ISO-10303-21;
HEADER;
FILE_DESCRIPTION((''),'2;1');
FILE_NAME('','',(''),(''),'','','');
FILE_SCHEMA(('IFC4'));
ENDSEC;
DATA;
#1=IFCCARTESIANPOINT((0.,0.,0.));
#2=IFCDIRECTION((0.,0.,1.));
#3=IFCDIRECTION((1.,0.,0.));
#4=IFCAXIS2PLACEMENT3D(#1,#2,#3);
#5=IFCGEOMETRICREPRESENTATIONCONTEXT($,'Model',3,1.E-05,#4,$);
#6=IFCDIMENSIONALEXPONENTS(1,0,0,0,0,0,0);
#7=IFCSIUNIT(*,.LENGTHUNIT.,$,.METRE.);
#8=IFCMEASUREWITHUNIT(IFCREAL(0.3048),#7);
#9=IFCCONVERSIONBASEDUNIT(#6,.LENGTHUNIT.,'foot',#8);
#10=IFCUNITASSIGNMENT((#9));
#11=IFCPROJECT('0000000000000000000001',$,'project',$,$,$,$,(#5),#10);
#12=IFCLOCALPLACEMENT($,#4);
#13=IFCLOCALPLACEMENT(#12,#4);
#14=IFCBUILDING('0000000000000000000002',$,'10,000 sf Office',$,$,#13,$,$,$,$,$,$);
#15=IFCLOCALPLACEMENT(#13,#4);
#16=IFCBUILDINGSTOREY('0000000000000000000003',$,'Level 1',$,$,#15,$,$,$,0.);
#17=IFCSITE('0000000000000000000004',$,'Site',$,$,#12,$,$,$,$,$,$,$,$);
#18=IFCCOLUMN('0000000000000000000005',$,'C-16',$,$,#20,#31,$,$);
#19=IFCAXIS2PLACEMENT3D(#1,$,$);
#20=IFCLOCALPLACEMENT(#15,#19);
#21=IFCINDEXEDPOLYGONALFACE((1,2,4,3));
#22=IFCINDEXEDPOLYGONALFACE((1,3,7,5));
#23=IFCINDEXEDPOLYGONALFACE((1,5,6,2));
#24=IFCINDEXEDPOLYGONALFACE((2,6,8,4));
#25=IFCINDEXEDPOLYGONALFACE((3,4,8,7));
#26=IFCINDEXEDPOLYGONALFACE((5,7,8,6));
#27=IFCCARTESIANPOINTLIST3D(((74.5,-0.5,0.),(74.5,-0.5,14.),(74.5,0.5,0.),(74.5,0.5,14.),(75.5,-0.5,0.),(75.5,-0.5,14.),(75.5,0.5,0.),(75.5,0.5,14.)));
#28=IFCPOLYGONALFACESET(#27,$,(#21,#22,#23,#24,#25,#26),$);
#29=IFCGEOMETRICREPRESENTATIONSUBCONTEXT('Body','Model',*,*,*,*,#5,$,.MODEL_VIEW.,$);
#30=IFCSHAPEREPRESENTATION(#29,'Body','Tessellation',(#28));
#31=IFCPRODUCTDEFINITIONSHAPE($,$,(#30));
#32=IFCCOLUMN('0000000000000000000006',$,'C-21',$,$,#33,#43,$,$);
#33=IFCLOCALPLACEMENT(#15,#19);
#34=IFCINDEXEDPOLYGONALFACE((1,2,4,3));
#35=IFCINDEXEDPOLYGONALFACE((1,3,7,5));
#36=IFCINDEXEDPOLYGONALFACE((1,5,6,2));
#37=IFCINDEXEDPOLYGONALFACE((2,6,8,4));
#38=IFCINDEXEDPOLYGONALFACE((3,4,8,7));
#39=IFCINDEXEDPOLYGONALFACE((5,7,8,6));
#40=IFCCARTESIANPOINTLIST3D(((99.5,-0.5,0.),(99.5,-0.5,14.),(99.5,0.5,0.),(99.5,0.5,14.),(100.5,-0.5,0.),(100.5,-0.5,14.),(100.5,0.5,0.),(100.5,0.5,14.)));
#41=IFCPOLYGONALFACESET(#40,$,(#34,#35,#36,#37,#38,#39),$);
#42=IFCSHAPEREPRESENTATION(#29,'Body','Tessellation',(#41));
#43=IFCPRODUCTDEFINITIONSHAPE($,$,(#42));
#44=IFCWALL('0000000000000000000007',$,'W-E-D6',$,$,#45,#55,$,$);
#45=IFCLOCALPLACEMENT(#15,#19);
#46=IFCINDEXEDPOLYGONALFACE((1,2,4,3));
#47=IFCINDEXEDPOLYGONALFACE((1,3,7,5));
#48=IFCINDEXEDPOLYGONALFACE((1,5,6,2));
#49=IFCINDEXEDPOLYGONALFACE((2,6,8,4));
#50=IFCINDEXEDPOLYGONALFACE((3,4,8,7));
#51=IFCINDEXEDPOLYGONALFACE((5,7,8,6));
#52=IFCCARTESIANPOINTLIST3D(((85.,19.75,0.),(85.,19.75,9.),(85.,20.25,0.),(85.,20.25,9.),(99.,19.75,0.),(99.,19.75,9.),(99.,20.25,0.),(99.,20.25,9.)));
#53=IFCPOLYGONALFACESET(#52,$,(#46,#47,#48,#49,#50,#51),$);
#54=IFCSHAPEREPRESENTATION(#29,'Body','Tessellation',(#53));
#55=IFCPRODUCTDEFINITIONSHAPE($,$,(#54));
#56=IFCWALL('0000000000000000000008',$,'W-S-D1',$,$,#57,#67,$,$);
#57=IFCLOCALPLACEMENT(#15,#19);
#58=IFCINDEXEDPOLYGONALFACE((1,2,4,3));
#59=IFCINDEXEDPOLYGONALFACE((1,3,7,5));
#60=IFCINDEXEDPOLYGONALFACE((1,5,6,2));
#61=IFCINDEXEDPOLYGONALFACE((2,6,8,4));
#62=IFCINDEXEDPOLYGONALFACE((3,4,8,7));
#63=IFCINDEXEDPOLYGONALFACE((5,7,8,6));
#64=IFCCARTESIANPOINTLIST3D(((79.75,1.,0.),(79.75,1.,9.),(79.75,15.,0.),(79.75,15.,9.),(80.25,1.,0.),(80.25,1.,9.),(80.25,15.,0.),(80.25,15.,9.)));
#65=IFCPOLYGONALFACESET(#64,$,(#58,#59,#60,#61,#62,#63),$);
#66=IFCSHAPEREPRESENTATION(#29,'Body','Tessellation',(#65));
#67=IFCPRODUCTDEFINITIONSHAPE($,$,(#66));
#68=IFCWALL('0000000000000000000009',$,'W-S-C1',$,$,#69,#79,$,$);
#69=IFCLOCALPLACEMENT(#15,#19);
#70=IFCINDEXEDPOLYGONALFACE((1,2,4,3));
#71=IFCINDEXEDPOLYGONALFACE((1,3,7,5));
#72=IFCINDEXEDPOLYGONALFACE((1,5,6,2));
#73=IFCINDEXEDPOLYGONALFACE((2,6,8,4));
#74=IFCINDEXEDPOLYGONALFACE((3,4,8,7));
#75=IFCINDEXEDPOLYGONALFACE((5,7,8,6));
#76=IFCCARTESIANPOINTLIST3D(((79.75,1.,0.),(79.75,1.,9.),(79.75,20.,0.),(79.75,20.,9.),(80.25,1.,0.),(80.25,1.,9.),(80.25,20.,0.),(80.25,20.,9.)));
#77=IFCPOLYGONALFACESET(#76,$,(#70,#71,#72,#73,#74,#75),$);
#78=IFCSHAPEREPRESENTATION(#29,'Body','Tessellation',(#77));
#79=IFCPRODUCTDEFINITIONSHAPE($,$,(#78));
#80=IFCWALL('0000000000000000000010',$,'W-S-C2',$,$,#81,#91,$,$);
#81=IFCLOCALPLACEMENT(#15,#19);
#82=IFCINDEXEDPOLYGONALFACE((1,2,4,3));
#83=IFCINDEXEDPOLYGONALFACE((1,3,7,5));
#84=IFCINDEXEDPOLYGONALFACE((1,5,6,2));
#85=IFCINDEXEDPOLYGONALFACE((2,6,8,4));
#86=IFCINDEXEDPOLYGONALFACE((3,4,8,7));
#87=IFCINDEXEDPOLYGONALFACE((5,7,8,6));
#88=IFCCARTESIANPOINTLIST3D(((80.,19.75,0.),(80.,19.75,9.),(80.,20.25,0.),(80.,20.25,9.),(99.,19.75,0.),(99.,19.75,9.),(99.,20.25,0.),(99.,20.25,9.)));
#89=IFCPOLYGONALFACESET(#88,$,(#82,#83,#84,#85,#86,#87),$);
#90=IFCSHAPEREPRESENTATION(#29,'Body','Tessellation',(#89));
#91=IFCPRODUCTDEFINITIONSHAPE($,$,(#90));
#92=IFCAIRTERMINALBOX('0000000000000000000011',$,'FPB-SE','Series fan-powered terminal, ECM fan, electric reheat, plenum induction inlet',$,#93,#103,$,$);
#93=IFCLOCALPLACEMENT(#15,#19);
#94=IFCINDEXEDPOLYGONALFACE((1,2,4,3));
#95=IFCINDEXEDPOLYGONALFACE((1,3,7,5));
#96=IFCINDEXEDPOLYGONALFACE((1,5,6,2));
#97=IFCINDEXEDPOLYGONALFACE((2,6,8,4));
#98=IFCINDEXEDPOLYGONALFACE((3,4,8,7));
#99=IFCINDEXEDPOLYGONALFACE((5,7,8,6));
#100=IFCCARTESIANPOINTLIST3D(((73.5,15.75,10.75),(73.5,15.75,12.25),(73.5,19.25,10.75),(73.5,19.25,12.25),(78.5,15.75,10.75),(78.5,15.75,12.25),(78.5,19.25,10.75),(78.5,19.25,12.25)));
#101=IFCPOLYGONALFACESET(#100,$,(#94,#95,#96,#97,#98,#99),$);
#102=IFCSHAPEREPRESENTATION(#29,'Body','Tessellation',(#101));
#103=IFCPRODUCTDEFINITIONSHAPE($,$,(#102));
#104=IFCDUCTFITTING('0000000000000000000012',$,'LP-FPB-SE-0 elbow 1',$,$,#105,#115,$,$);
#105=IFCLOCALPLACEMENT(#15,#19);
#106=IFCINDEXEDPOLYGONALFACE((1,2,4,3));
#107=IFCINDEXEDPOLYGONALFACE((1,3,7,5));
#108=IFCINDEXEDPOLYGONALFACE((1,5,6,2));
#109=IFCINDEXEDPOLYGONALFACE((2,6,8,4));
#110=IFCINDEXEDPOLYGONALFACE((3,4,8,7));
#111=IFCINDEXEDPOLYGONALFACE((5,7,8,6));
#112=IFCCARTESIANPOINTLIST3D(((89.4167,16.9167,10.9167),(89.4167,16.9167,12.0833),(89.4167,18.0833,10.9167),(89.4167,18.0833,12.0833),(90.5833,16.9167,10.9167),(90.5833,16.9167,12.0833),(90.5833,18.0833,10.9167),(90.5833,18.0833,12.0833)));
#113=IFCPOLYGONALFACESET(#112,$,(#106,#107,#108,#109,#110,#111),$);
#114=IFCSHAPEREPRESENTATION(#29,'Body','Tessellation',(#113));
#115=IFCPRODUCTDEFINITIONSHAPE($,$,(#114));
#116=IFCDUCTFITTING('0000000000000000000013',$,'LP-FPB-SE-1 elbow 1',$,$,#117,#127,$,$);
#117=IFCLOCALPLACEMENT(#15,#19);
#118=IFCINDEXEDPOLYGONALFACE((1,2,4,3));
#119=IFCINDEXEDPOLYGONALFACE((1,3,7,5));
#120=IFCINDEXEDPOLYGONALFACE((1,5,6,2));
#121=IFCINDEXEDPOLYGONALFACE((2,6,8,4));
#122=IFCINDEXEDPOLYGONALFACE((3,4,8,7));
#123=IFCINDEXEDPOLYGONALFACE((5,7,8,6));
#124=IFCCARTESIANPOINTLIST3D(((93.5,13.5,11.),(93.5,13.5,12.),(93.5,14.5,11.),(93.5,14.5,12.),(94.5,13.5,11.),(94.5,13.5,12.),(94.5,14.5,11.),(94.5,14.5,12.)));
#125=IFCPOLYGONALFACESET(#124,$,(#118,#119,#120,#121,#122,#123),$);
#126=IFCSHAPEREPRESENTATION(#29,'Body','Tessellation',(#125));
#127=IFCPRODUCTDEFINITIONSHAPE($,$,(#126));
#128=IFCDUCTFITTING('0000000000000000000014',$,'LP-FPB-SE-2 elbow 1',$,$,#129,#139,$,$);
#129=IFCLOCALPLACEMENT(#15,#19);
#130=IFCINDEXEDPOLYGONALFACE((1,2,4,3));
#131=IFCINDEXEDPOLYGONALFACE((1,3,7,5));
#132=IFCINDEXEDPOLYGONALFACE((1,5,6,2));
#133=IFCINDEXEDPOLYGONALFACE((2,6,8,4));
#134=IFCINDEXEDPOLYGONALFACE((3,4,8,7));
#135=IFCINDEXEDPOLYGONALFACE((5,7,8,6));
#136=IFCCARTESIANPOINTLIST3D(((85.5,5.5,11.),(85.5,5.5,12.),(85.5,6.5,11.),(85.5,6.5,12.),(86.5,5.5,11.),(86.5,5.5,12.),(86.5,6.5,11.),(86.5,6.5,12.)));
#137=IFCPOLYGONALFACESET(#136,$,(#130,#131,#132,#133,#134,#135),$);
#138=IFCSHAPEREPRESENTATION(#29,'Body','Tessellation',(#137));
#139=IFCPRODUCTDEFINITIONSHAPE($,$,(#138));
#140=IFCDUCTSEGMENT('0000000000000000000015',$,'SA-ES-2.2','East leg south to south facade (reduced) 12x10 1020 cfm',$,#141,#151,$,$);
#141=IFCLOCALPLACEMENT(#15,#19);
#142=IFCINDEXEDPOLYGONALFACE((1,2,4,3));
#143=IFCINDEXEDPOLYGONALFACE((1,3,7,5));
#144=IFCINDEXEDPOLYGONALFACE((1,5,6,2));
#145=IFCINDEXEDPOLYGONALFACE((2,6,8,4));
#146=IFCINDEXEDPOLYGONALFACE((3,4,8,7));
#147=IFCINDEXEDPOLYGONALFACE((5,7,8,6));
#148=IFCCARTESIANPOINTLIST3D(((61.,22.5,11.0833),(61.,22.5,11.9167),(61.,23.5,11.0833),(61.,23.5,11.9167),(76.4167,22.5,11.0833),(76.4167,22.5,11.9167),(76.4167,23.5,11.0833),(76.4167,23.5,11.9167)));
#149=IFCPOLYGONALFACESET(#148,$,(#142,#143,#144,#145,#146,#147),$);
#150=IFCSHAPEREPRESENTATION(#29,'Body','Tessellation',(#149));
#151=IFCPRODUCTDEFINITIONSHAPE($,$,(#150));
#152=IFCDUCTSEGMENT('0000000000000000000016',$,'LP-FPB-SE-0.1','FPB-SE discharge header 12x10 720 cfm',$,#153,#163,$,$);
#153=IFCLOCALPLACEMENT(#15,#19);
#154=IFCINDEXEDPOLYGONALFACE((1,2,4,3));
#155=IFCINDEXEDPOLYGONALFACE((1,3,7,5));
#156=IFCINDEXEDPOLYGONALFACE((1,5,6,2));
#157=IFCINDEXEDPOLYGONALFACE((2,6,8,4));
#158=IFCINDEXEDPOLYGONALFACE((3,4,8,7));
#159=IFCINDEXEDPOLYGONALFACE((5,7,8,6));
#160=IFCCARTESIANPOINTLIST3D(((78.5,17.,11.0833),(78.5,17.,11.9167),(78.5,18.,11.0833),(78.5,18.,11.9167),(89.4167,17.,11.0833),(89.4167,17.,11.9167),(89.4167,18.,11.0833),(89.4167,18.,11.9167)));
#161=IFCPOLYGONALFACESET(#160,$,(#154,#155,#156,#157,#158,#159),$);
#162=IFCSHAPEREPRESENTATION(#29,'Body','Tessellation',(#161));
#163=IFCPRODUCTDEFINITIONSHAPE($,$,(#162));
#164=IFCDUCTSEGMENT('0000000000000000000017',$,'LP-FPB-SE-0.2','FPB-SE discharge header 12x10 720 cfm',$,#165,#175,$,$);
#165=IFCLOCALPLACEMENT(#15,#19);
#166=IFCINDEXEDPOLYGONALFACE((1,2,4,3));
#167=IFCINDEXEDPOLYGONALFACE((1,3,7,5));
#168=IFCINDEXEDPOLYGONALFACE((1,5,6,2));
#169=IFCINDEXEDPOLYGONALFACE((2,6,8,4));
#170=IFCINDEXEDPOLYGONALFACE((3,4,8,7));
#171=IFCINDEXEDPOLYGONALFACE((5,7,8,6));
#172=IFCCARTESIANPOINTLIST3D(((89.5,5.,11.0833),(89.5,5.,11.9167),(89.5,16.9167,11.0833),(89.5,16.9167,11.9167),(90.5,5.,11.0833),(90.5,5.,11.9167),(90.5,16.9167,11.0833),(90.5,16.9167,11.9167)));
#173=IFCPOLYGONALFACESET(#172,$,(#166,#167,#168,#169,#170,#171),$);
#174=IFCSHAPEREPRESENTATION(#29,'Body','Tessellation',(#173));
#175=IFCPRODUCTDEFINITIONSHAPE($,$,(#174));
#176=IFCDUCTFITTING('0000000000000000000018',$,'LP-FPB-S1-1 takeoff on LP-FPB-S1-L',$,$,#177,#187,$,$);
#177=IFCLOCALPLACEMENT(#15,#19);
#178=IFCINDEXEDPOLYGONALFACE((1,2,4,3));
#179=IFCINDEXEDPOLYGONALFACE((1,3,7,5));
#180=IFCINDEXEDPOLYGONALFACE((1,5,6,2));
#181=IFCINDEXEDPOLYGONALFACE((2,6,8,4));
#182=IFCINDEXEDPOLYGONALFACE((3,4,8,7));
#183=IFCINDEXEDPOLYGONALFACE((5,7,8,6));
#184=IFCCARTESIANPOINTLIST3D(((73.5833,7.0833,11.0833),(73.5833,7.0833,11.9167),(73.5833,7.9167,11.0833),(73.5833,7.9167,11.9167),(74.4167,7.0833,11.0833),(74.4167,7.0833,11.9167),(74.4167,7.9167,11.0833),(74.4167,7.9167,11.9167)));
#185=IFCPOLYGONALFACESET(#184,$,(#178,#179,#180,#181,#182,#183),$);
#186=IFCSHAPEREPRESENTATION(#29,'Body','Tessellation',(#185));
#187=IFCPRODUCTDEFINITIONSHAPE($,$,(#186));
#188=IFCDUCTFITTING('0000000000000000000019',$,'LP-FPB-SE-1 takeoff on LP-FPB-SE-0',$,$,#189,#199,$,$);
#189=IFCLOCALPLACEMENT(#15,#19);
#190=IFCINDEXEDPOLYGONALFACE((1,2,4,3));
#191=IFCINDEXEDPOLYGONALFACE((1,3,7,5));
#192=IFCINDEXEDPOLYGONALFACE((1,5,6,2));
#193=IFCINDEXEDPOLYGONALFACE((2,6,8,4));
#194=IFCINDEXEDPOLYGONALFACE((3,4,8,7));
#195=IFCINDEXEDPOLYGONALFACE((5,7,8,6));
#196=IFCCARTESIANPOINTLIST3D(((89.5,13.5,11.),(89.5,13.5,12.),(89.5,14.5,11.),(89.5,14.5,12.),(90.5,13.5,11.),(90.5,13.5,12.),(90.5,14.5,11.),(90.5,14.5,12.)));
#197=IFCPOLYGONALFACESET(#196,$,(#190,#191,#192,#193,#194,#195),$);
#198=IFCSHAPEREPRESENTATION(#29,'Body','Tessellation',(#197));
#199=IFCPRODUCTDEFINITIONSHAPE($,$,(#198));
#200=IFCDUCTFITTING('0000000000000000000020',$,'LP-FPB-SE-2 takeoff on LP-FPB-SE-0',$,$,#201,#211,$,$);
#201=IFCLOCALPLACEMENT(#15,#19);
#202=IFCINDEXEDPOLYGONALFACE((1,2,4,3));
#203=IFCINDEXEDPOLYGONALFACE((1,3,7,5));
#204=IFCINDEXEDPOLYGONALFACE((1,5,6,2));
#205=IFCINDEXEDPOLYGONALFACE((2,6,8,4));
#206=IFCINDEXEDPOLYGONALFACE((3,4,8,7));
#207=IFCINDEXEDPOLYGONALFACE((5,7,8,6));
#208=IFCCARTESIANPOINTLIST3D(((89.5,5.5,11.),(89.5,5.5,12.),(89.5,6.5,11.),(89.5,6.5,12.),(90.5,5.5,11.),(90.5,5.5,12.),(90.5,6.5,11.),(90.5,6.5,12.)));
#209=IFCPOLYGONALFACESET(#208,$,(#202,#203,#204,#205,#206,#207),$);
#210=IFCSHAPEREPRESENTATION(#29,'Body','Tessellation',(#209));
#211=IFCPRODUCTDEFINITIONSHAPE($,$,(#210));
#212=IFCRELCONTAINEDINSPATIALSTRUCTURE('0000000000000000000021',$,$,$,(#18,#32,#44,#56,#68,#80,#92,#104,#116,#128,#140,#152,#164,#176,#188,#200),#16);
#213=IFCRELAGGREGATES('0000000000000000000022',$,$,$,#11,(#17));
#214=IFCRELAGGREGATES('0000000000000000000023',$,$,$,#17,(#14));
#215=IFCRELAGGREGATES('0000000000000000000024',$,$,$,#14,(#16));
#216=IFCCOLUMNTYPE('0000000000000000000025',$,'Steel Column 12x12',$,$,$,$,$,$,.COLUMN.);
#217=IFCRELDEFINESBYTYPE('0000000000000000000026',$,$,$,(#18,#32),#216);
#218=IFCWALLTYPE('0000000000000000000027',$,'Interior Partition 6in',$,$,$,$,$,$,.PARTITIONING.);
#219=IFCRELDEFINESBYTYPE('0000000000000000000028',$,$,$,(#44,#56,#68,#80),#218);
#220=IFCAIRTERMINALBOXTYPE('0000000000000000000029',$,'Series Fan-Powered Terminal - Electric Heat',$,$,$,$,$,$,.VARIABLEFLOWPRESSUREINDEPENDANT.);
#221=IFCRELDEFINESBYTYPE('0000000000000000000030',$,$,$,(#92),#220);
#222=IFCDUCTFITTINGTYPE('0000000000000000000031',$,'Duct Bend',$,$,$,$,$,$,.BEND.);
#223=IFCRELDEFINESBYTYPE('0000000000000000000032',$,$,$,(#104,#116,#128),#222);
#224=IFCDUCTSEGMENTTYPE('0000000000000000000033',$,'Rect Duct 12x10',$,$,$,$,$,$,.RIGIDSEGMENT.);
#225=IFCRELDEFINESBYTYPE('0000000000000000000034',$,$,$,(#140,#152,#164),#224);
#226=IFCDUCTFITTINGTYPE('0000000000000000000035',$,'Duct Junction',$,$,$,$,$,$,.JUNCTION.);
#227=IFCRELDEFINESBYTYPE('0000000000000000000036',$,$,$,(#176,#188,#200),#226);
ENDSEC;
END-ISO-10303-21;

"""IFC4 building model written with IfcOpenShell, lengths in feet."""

from ifc_helpers import new_model, entity, si_unit, converted_unit, frame, origin_with_axes, place, context, subcontext, project, spatial, rectangle, extrude, type_object, element, save


model = new_model("IFC4")

# Units and contexts
model_context = context("Model", 3, precision=1e-05, world=origin_with_axes())
body_context = subcontext(model_context, "Body", "Model", "MODEL_VIEW")
ifc_project = project(units=[converted_unit("LENGTHUNIT", "foot", entity("IfcReal", 0.3048), si_unit("LENGTHUNIT", "METRE"), dimensions=[1, 0, 0, 0, 0, 0, 0])], contexts=[model_context])

# Site, building, storey
site_placement = place(None, origin_with_axes())
site = spatial("IfcSite", under=ifc_project, at=site_placement, Name="Site")
building_placement = place(site_placement, origin_with_axes())
building = spatial("IfcBuilding", under=site, at=building_placement, Name="10,000 sf Office")
storey_placement = place(building_placement, origin_with_axes())
storey = spatial("IfcBuildingStorey", under=building, at=storey_placement, Name="Level 1", Elevation=0.0)

# Columns
column_type = type_object("IfcColumnType", Name="Steel Column 12x12", PredefinedType="COLUMN")
for number, where, z_axis, x_axis, name in (
    (1, (75.0, 0.0, 0.0), (0.0, 0.0, 1.0), (1.0, 0.0, 0.0), "C-16"),
    (2, (100.0, 0.0, 0.0), (0.0, 0.0, 1.0), (1.0, 0.0, 0.0), "C-21"),
):
    element("IfcColumn", number, at=place(storey_placement, frame(where, z_axis=z_axis, x_axis=x_axis)), inside=storey, type_object=column_type, Name=name, context=body_context, shape_type="SweptSolid", body=[
        extrude(rectangle(XDim=1.0, YDim=1.0), None, (0.0, 0.0, 1.0), 14.0),
    ])

# Walls
wall_type = type_object("IfcWallType", Name="Interior Partition 6in", PredefinedType="PARTITIONING")
for number, where, z_axis, x_axis, name in (
    (3, (92.0, 20.0, 0.0), (0.0, 0.0, 1.0), (-1.0, 0.0, 0.0), "W-E-D6"),
    (4, (80.0, 8.0, 0.0), (0.0, 0.0, 1.0), (0.0, 1.0, 0.0), "W-S-D1"),
):
    element("IfcWall", number, at=place(storey_placement, frame(where, z_axis=z_axis, x_axis=x_axis)), inside=storey, type_object=wall_type, Name=name, context=body_context, shape_type="SweptSolid", body=[
        extrude(rectangle(XDim=14.0, YDim=0.5), None, (0.0, 0.0, 1.0), 9.0),
    ])
for number, where, z_axis, x_axis, name in (
    (5, (80.0, 10.5, 0.0), (0.0, 0.0, 1.0), (0.0, 1.0, 0.0), "W-S-C1"),
    (6, (89.5, 20.0, 0.0), (0.0, 0.0, 1.0), (1.0, 0.0, 0.0), "W-S-C2"),
):
    element("IfcWall", number, at=place(storey_placement, frame(where, z_axis=z_axis, x_axis=x_axis)), inside=storey, type_object=wall_type, Name=name, context=body_context, shape_type="SweptSolid", body=[
        extrude(rectangle(XDim=19.0, YDim=0.5), None, (0.0, 0.0, 1.0), 9.0),
    ])

# Air terminal box
air_terminal_box_type = type_object("IfcAirTerminalBoxType", Name="Series Fan-Powered Terminal - Electric Heat", PredefinedType="VARIABLEFLOWPRESSUREINDEPENDANT")
air_terminal_box_placement = place(storey_placement, frame((76.0, 17.5, 10.75), z_axis=(0.0, 0.0, 1.0), x_axis=(1.0, 0.0, 0.0)))
element("IfcAirTerminalBox", 7, at=air_terminal_box_placement, inside=storey, type_object=air_terminal_box_type, Name="FPB-SE", Description="Series fan-powered terminal, ECM fan, electric reheat, plenum induction inlet", context=body_context, shape_type="SweptSolid", body=[
    extrude(rectangle(XDim=5.0, YDim=3.5), None, (0.0, 0.0, 1.0), 1.5),
])

# Duct fittings
duct_fitting_type_1 = type_object("IfcDuctFittingType", Name="Duct Bend", PredefinedType="BEND")
duct_fitting_1_placement = place(storey_placement, frame((90.0, 17.5, 10.9167), z_axis=(0.0, 0.0, 1.0), x_axis=(1.0, 0.0, 0.0)))
element("IfcDuctFitting", 8, at=duct_fitting_1_placement, inside=storey, type_object=duct_fitting_type_1, Name="LP-FPB-SE-0 elbow 1", context=body_context, shape_type="SweptSolid", body=[
    extrude(rectangle(XDim=1.1667, YDim=1.1667), None, (0.0, 0.0, 1.0), 1.1667),
])
for number, where, z_axis, x_axis, name in (
    (9, (94.0, 14.0, 11.0), (0.0, 0.0, 1.0), (1.0, 0.0, 0.0), "LP-FPB-SE-1 elbow 1"),
    (10, (86.0, 6.0, 11.0), (0.0, 0.0, 1.0), (1.0, 0.0, 0.0), "LP-FPB-SE-2 elbow 1"),
):
    element("IfcDuctFitting", number, at=place(storey_placement, frame(where, z_axis=z_axis, x_axis=x_axis)), inside=storey, type_object=duct_fitting_type_1, Name=name, context=body_context, shape_type="SweptSolid", body=[
        extrude(rectangle(XDim=1.0, YDim=1.0), None, (0.0, 0.0, 1.0), 1.0),
    ])

# Duct segments
duct_segment_type_1 = type_object("IfcDuctSegmentType", Name="Rect Duct 12x10", PredefinedType="RIGIDSEGMENT")
duct_segment_1_placement = place(storey_placement, frame((76.4167, 23.0, 11.5), z_axis=(-1.0, 0.0, 0.0), x_axis=(0.0, -1.0, 0.0)))
element("IfcDuctSegment", 11, at=duct_segment_1_placement, inside=storey, type_object=duct_segment_type_1, Name="SA-ES-2.2", Description="East leg south to south facade (reduced) 12x10 1020 cfm", context=body_context, shape_type="SweptSolid", body=[
    extrude(rectangle(XDim=1.0, YDim=0.8333), None, (0.0, 0.0, 1.0), 15.4167),
])
duct_segment_2_placement = place(storey_placement, frame((78.5, 17.5, 11.5), z_axis=(1.0, 0.0, 0.0), x_axis=(0.0, 1.0, 0.0)))
element("IfcDuctSegment", 12, at=duct_segment_2_placement, inside=storey, type_object=duct_segment_type_1, Name="LP-FPB-SE-0.1", Description="FPB-SE discharge header 12x10 720 cfm", context=body_context, shape_type="SweptSolid", body=[
    extrude(rectangle(XDim=1.0, YDim=0.8333), None, (0.0, 0.0, 1.0), 10.9167),
])
duct_segment_3_placement = place(storey_placement, frame((90.0, 16.9167, 11.5), z_axis=(0.0, -1.0, 0.0), x_axis=(1.0, 0.0, 0.0)))
element("IfcDuctSegment", 13, at=duct_segment_3_placement, inside=storey, type_object=duct_segment_type_1, Name="LP-FPB-SE-0.2", Description="FPB-SE discharge header 12x10 720 cfm", context=body_context, shape_type="SweptSolid", body=[
    extrude(rectangle(XDim=1.0, YDim=0.8333), None, (0.0, 0.0, 1.0), 11.9167),
])

# Duct fittings
duct_fitting_type_2 = type_object("IfcDuctFittingType", Name="Duct Junction", PredefinedType="JUNCTION")
duct_fitting_2_placement = place(storey_placement, frame((74.0, 7.5, 11.0833), z_axis=(0.0, 0.0, 1.0), x_axis=(1.0, 0.0, 0.0)))
element("IfcDuctFitting", 14, at=duct_fitting_2_placement, inside=storey, type_object=duct_fitting_type_2, Name="LP-FPB-S1-1 takeoff on LP-FPB-S1-L", context=body_context, shape_type="SweptSolid", body=[
    extrude(rectangle(XDim=0.8333, YDim=0.8333), None, (0.0, 0.0, 1.0), 0.8333),
])
for number, where, z_axis, x_axis, name in (
    (15, (90.0, 14.0, 11.0), (0.0, 0.0, 1.0), (1.0, 0.0, 0.0), "LP-FPB-SE-1 takeoff on LP-FPB-SE-0"),
    (16, (90.0, 6.0, 11.0), (0.0, 0.0, 1.0), (1.0, 0.0, 0.0), "LP-FPB-SE-2 takeoff on LP-FPB-SE-0"),
):
    element("IfcDuctFitting", number, at=place(storey_placement, frame(where, z_axis=z_axis, x_axis=x_axis)), inside=storey, type_object=duct_fitting_type_2, Name=name, context=body_context, shape_type="SweptSolid", body=[
        extrude(rectangle(XDim=1.0, YDim=1.0), None, (0.0, 0.0, 1.0), 1.0),
    ])

save(model, "model.ifc")
